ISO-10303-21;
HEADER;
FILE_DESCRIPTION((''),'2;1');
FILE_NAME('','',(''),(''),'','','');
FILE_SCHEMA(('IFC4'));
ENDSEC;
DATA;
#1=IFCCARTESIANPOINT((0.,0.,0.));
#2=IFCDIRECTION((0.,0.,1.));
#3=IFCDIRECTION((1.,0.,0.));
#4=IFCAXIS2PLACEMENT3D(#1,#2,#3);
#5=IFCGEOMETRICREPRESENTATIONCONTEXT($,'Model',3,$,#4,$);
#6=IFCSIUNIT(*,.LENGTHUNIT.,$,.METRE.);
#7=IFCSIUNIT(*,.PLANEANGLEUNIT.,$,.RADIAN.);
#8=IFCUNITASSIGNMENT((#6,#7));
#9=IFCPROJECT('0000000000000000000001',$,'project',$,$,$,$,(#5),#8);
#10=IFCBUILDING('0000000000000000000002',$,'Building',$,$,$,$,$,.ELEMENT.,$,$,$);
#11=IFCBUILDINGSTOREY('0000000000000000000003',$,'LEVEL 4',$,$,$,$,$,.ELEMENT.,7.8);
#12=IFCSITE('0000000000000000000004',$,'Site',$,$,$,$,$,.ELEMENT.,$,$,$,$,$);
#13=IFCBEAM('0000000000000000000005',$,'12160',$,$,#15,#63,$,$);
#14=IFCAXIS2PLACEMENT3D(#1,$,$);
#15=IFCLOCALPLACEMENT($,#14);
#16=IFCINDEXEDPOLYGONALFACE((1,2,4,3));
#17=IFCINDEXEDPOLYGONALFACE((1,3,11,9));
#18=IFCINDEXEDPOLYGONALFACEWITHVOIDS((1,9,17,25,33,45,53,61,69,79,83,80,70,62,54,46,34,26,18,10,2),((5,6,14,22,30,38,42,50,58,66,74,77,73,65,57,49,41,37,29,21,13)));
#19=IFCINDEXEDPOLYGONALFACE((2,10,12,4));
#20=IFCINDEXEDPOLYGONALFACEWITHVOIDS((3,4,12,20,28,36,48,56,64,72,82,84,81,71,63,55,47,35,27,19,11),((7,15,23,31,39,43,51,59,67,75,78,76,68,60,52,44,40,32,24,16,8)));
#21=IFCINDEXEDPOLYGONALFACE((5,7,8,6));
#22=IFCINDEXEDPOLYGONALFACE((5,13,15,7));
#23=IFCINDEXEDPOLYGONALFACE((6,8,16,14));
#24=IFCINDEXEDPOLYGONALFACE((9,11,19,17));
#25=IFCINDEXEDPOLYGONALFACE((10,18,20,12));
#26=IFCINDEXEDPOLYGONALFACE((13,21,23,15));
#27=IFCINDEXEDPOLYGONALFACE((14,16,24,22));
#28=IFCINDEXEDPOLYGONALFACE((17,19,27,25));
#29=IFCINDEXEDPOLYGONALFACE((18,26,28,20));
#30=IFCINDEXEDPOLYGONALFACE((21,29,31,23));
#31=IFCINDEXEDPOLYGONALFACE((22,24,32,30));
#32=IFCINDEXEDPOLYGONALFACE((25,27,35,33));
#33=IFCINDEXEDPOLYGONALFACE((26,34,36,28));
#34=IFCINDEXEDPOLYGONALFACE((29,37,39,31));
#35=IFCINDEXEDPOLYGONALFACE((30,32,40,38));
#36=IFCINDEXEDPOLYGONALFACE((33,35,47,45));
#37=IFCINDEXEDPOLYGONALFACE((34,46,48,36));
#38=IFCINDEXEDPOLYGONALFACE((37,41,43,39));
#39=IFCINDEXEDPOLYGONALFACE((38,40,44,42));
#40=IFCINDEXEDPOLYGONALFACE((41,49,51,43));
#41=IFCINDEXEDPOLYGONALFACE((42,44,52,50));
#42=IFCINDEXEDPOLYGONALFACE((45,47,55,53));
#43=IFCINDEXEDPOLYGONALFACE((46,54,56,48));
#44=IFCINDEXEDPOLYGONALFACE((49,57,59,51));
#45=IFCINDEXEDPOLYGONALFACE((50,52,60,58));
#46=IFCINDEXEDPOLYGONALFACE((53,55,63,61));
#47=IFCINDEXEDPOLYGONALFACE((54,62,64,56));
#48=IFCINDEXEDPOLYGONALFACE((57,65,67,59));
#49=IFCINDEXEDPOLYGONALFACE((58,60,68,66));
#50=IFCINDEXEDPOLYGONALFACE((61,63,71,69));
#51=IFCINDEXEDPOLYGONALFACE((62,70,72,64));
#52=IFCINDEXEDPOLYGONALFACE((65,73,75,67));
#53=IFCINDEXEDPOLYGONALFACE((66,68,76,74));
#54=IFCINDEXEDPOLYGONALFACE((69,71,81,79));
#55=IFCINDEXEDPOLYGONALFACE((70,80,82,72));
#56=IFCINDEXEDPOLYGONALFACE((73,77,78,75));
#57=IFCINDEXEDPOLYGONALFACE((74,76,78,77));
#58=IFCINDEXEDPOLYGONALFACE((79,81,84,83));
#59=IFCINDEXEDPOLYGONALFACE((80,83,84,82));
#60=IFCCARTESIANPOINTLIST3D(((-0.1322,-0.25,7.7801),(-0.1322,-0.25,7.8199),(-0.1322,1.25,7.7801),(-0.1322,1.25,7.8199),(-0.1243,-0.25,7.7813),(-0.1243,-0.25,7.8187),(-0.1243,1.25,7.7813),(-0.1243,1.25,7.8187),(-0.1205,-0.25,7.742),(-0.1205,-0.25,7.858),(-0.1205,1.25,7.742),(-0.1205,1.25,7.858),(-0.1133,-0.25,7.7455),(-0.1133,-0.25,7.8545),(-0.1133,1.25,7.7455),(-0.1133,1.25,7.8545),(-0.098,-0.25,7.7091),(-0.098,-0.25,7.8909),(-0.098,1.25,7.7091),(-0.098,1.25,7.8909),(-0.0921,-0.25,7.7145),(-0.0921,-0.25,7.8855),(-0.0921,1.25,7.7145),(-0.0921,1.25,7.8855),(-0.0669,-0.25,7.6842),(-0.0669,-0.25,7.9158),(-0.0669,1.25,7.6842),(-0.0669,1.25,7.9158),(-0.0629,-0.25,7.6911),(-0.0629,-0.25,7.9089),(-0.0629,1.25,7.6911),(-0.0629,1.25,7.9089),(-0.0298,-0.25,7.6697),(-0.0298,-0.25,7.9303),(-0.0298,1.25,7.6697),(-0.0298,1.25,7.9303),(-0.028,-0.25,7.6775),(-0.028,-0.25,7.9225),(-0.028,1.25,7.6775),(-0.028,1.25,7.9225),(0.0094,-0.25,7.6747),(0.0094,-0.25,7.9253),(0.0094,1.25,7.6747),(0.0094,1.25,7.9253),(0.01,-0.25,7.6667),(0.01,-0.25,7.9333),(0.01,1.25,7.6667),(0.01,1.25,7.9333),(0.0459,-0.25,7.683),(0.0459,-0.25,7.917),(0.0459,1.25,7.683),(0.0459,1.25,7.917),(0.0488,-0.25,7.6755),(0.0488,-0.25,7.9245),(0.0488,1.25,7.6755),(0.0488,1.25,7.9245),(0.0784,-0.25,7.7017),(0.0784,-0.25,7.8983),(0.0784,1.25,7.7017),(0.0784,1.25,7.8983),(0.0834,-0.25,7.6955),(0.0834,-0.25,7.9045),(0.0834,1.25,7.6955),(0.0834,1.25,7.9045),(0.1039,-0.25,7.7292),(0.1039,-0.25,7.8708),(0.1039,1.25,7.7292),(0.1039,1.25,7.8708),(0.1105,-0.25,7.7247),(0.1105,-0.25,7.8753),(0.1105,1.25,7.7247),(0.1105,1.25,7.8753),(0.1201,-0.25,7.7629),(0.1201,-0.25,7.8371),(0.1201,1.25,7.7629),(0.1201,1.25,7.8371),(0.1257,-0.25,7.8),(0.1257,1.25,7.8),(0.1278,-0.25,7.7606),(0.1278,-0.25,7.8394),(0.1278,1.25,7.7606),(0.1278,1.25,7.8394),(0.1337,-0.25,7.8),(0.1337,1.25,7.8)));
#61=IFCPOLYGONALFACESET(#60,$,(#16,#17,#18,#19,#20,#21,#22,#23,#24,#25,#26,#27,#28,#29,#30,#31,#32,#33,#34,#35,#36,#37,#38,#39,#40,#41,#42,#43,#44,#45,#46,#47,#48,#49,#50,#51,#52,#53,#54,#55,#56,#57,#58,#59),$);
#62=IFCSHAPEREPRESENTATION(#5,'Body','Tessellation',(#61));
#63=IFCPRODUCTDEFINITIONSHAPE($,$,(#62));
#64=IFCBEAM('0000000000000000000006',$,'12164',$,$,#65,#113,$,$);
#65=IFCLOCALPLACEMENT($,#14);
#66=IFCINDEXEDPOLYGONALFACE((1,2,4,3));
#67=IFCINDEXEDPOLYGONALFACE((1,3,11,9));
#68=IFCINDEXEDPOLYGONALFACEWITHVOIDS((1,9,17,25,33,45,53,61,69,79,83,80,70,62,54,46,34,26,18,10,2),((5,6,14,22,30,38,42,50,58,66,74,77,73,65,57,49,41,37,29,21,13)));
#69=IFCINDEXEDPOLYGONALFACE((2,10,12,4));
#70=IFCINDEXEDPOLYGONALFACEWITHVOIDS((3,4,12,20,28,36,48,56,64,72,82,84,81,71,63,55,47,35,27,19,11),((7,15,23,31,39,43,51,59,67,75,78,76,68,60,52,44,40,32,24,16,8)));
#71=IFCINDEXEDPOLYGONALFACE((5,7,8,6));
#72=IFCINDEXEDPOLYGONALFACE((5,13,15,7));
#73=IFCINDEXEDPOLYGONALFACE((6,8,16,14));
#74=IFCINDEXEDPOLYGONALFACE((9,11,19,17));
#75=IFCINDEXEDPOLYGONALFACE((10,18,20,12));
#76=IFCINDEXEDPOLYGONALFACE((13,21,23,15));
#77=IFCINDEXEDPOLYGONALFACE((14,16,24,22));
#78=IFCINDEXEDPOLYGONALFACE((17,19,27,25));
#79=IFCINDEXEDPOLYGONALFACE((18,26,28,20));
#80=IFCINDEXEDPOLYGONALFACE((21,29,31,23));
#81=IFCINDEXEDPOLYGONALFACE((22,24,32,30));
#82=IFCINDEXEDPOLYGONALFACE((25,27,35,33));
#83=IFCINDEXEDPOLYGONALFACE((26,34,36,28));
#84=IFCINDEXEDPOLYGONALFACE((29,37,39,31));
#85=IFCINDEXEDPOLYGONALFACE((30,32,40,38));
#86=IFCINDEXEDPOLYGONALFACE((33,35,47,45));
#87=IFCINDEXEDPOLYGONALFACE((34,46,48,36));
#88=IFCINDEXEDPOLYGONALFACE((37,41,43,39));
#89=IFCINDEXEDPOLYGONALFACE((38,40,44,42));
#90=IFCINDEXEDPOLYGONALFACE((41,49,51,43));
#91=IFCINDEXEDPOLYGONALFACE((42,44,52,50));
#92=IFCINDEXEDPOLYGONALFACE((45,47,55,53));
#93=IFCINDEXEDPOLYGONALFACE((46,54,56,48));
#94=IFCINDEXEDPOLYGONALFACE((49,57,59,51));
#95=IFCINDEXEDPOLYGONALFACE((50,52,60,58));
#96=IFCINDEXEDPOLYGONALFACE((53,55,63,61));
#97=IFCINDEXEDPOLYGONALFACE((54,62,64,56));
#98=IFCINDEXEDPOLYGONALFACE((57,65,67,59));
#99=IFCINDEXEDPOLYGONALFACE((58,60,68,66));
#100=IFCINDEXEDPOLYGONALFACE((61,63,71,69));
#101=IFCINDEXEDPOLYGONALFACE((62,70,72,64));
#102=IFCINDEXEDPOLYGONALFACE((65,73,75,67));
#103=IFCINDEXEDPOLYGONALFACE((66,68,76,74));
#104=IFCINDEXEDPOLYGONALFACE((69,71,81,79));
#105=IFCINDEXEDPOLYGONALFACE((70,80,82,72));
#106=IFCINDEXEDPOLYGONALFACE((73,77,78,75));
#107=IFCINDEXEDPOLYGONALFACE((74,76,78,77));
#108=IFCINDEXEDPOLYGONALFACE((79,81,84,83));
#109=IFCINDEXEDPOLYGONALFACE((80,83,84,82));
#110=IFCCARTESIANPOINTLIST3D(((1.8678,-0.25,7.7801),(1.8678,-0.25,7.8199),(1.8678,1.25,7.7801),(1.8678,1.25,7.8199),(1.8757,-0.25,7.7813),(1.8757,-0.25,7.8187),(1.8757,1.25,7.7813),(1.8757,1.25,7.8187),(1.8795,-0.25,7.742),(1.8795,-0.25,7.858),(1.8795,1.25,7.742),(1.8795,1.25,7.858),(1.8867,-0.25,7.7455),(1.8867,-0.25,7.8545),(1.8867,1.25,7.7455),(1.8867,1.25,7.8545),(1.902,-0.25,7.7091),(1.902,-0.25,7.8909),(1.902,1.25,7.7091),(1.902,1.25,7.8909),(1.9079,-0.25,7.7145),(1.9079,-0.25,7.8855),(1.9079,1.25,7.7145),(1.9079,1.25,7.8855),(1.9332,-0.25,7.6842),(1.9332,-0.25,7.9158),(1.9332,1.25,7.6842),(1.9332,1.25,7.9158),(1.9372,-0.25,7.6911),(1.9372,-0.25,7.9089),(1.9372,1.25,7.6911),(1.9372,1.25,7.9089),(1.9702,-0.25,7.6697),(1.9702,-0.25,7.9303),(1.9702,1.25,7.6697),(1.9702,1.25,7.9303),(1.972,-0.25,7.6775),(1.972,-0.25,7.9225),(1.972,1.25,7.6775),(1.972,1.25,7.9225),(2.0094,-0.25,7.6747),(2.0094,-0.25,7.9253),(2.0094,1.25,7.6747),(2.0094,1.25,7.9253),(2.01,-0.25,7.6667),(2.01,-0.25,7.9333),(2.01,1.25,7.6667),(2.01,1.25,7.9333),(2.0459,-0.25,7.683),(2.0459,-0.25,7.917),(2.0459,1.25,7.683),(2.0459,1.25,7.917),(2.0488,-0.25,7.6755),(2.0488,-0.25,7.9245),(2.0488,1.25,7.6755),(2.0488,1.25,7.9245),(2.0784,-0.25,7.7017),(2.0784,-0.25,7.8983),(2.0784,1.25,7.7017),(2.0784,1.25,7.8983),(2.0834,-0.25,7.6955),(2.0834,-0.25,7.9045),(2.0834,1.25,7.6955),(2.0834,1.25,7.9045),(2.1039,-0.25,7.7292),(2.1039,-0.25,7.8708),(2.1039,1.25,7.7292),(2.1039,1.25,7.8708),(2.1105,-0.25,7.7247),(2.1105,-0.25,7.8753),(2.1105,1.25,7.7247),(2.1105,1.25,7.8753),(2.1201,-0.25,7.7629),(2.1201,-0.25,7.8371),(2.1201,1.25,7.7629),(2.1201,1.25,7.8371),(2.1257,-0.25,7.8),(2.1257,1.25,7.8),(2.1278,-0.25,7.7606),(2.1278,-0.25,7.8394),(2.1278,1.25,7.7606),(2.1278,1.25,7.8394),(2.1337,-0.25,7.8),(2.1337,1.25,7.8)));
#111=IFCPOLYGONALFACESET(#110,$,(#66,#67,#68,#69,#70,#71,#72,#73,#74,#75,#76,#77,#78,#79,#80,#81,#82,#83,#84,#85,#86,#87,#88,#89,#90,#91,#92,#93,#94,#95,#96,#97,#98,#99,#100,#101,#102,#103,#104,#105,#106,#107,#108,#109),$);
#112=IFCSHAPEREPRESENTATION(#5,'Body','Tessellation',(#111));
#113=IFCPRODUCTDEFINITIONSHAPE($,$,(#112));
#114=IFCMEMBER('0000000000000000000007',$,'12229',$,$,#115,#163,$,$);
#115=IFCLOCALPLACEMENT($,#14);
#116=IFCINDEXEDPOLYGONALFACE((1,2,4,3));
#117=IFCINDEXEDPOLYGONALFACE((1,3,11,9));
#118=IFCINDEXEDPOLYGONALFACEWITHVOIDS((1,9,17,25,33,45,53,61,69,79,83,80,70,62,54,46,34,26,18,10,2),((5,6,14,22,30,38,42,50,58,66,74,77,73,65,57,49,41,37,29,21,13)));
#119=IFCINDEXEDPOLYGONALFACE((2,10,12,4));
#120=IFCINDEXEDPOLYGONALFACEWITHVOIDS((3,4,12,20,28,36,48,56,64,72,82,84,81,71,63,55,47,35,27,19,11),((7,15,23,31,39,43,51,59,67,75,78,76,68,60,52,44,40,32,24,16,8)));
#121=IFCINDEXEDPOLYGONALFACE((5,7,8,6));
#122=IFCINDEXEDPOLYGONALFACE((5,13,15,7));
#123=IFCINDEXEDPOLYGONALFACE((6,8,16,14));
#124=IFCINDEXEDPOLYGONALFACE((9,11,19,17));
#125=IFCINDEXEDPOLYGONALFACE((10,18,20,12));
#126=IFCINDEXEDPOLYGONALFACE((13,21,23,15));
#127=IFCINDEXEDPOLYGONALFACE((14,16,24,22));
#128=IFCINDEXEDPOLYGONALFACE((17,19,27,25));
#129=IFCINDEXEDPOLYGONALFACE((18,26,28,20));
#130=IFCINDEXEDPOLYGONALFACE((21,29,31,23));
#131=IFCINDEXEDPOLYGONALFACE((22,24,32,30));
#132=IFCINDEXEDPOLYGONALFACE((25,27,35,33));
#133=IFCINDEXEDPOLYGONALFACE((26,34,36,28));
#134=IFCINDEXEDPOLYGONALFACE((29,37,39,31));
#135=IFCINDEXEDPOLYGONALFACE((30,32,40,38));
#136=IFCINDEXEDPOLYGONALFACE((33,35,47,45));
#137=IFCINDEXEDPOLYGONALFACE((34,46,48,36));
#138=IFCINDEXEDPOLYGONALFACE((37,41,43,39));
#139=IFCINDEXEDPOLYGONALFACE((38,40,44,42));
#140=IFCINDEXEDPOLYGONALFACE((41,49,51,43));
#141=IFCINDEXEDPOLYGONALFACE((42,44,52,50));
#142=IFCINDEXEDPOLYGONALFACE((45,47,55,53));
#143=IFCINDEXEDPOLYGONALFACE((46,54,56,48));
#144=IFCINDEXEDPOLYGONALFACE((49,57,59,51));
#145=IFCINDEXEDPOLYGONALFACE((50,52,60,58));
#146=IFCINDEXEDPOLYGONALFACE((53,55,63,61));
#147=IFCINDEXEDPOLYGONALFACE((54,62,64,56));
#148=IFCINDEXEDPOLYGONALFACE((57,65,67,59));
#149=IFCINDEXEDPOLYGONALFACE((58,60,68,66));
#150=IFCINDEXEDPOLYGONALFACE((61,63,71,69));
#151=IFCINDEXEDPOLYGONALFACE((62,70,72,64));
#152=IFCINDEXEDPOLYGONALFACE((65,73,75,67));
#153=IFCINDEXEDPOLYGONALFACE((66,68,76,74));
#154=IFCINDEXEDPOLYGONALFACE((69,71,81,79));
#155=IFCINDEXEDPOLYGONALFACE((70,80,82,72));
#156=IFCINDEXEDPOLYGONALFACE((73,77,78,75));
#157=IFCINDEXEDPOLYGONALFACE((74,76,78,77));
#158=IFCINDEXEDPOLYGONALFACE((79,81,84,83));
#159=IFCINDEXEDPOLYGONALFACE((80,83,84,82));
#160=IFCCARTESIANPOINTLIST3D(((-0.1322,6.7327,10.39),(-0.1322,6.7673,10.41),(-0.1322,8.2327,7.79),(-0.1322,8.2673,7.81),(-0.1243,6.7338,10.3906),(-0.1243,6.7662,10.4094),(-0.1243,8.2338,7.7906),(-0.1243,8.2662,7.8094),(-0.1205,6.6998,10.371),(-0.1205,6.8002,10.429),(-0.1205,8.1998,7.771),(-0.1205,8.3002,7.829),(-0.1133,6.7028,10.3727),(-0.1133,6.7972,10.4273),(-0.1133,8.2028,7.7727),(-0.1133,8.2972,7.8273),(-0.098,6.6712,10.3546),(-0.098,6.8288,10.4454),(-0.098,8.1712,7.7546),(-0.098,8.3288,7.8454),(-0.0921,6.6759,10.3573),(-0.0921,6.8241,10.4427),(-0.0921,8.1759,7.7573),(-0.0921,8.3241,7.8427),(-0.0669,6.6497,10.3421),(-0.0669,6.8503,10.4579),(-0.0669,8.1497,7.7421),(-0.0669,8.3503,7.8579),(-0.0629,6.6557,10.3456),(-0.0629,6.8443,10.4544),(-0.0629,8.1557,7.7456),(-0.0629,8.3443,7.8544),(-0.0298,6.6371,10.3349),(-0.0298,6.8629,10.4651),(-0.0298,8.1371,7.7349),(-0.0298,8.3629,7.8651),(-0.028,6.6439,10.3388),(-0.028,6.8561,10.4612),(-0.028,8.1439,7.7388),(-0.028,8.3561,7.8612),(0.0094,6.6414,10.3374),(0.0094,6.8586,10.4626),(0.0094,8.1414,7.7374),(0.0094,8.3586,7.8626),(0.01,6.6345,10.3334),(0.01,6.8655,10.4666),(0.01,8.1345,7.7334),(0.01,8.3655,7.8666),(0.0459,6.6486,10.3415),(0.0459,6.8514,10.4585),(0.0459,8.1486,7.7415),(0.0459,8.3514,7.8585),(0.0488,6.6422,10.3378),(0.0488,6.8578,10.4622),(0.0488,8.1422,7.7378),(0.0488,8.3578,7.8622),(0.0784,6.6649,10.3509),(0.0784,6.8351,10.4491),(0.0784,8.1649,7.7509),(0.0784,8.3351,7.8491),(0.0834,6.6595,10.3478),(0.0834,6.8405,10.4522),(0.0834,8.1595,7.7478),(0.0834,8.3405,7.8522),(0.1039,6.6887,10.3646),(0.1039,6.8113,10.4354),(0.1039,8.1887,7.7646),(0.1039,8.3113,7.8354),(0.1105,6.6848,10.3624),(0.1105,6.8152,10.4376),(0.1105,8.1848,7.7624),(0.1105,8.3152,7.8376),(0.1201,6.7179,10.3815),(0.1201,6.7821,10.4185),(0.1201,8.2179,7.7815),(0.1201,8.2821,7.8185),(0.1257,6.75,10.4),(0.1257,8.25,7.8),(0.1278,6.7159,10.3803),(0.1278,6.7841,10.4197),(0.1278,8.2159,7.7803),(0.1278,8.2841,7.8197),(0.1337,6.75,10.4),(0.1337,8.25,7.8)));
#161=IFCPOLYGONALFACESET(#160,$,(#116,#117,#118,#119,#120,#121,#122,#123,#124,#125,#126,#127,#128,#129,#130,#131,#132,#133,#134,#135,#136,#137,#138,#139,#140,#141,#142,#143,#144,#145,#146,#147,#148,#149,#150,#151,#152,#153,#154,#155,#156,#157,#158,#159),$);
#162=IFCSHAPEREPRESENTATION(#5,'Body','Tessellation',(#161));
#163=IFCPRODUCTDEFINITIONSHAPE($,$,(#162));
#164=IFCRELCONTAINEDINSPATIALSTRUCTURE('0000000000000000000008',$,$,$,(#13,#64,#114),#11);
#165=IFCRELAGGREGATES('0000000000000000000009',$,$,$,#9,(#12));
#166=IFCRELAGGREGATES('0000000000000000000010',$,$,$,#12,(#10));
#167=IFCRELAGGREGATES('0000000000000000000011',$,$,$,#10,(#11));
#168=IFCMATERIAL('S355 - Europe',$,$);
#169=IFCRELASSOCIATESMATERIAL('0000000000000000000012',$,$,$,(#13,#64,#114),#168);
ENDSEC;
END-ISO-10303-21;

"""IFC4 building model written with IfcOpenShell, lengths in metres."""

from ifc_helpers import new_model, si_unit, frame, origin_with_axes, origin_2d_with_axis, place, context, project, spatial, hollow_circle, extrude, material, material_profile, profile_set, profile_usage, element, save


model = new_model("IFC4")

# Units and contexts
model_context = context("Model", 3, world=origin_with_axes())
ifc_project = project(units=[si_unit("LENGTHUNIT", "METRE"), si_unit("PLANEANGLEUNIT", "RADIAN")], contexts=[model_context])

# Site, building, storey
site = spatial("IfcSite", under=ifc_project, Name="Site", CompositionType="ELEMENT")
building = spatial("IfcBuilding", under=site, Name="Building", CompositionType="ELEMENT")
storey = spatial("IfcBuildingStorey", under=building, Name="LEVEL 4", CompositionType="ELEMENT", Elevation=7.8)

# Shared definitions
ifc_material = material(Name="S355 - Europe")

# Beams
ifc_material_profile_1 = material_profile(ifc_material, hollow_circle(Radius=0.1337, WallThickness=0.008, at=origin_2d_with_axis()))
ifc_profile_set_1 = profile_set([ifc_material_profile_1])
ifc_profile_usage_1 = profile_usage(ifc_profile_set_1, cardinal=10)
beam_1_placement = place(None, frame((0.0, 1.25, 7.8), z_axis=(0.0, -1.0, 0.0), x_axis=(1.0, 0.0, 0.0)))
element("IfcBeam", 1, at=beam_1_placement, inside=storey, material=ifc_profile_usage_1, Name="12160", context=model_context, shape_type="SweptSolid", body=[
    extrude(hollow_circle(Radius=0.1337, WallThickness=0.008, at=origin_2d_with_axis()), origin_with_axes(), (0.0, 0.0, 1.0), 1.5),
])
ifc_material_profile_2 = material_profile(ifc_material, hollow_circle(Radius=0.1337, WallThickness=0.008, at=origin_2d_with_axis()))
ifc_profile_set_2 = profile_set([ifc_material_profile_2])
ifc_profile_usage_2 = profile_usage(ifc_profile_set_2, cardinal=10)
beam_2_placement = place(None, frame((2.0, 1.25, 7.8), z_axis=(0.0, -1.0, 0.0), x_axis=(1.0, 0.0, 0.0)))
element("IfcBeam", 2, at=beam_2_placement, inside=storey, material=ifc_profile_usage_2, Name="12164", context=model_context, shape_type="SweptSolid", body=[
    extrude(hollow_circle(Radius=0.1337, WallThickness=0.008, at=origin_2d_with_axis()), origin_with_axes(), (0.0, 0.0, 1.0), 1.5),
])

# Member
ifc_material_profile_3 = material_profile(ifc_material, hollow_circle(Radius=0.1337, WallThickness=0.008, at=origin_2d_with_axis()))
ifc_profile_set_3 = profile_set([ifc_material_profile_3])
ifc_profile_usage_3 = profile_usage(ifc_profile_set_3, cardinal=10)
member_1_placement = place(None, frame((0.0, 8.25, 7.8), z_axis=(0.0, -0.499722, 0.866186), x_axis=(1.0, 0.0, 0.0)))
element("IfcMember", 3, at=member_1_placement, inside=storey, material=ifc_profile_usage_3, Name="12229", context=model_context, shape_type="SweptSolid", body=[
    extrude(hollow_circle(Radius=0.1337, WallThickness=0.008, at=origin_2d_with_axis()), origin_with_axes(), (0.0, 0.0, 1.0), 3.0017),
])

save(model, "model.ifc")
